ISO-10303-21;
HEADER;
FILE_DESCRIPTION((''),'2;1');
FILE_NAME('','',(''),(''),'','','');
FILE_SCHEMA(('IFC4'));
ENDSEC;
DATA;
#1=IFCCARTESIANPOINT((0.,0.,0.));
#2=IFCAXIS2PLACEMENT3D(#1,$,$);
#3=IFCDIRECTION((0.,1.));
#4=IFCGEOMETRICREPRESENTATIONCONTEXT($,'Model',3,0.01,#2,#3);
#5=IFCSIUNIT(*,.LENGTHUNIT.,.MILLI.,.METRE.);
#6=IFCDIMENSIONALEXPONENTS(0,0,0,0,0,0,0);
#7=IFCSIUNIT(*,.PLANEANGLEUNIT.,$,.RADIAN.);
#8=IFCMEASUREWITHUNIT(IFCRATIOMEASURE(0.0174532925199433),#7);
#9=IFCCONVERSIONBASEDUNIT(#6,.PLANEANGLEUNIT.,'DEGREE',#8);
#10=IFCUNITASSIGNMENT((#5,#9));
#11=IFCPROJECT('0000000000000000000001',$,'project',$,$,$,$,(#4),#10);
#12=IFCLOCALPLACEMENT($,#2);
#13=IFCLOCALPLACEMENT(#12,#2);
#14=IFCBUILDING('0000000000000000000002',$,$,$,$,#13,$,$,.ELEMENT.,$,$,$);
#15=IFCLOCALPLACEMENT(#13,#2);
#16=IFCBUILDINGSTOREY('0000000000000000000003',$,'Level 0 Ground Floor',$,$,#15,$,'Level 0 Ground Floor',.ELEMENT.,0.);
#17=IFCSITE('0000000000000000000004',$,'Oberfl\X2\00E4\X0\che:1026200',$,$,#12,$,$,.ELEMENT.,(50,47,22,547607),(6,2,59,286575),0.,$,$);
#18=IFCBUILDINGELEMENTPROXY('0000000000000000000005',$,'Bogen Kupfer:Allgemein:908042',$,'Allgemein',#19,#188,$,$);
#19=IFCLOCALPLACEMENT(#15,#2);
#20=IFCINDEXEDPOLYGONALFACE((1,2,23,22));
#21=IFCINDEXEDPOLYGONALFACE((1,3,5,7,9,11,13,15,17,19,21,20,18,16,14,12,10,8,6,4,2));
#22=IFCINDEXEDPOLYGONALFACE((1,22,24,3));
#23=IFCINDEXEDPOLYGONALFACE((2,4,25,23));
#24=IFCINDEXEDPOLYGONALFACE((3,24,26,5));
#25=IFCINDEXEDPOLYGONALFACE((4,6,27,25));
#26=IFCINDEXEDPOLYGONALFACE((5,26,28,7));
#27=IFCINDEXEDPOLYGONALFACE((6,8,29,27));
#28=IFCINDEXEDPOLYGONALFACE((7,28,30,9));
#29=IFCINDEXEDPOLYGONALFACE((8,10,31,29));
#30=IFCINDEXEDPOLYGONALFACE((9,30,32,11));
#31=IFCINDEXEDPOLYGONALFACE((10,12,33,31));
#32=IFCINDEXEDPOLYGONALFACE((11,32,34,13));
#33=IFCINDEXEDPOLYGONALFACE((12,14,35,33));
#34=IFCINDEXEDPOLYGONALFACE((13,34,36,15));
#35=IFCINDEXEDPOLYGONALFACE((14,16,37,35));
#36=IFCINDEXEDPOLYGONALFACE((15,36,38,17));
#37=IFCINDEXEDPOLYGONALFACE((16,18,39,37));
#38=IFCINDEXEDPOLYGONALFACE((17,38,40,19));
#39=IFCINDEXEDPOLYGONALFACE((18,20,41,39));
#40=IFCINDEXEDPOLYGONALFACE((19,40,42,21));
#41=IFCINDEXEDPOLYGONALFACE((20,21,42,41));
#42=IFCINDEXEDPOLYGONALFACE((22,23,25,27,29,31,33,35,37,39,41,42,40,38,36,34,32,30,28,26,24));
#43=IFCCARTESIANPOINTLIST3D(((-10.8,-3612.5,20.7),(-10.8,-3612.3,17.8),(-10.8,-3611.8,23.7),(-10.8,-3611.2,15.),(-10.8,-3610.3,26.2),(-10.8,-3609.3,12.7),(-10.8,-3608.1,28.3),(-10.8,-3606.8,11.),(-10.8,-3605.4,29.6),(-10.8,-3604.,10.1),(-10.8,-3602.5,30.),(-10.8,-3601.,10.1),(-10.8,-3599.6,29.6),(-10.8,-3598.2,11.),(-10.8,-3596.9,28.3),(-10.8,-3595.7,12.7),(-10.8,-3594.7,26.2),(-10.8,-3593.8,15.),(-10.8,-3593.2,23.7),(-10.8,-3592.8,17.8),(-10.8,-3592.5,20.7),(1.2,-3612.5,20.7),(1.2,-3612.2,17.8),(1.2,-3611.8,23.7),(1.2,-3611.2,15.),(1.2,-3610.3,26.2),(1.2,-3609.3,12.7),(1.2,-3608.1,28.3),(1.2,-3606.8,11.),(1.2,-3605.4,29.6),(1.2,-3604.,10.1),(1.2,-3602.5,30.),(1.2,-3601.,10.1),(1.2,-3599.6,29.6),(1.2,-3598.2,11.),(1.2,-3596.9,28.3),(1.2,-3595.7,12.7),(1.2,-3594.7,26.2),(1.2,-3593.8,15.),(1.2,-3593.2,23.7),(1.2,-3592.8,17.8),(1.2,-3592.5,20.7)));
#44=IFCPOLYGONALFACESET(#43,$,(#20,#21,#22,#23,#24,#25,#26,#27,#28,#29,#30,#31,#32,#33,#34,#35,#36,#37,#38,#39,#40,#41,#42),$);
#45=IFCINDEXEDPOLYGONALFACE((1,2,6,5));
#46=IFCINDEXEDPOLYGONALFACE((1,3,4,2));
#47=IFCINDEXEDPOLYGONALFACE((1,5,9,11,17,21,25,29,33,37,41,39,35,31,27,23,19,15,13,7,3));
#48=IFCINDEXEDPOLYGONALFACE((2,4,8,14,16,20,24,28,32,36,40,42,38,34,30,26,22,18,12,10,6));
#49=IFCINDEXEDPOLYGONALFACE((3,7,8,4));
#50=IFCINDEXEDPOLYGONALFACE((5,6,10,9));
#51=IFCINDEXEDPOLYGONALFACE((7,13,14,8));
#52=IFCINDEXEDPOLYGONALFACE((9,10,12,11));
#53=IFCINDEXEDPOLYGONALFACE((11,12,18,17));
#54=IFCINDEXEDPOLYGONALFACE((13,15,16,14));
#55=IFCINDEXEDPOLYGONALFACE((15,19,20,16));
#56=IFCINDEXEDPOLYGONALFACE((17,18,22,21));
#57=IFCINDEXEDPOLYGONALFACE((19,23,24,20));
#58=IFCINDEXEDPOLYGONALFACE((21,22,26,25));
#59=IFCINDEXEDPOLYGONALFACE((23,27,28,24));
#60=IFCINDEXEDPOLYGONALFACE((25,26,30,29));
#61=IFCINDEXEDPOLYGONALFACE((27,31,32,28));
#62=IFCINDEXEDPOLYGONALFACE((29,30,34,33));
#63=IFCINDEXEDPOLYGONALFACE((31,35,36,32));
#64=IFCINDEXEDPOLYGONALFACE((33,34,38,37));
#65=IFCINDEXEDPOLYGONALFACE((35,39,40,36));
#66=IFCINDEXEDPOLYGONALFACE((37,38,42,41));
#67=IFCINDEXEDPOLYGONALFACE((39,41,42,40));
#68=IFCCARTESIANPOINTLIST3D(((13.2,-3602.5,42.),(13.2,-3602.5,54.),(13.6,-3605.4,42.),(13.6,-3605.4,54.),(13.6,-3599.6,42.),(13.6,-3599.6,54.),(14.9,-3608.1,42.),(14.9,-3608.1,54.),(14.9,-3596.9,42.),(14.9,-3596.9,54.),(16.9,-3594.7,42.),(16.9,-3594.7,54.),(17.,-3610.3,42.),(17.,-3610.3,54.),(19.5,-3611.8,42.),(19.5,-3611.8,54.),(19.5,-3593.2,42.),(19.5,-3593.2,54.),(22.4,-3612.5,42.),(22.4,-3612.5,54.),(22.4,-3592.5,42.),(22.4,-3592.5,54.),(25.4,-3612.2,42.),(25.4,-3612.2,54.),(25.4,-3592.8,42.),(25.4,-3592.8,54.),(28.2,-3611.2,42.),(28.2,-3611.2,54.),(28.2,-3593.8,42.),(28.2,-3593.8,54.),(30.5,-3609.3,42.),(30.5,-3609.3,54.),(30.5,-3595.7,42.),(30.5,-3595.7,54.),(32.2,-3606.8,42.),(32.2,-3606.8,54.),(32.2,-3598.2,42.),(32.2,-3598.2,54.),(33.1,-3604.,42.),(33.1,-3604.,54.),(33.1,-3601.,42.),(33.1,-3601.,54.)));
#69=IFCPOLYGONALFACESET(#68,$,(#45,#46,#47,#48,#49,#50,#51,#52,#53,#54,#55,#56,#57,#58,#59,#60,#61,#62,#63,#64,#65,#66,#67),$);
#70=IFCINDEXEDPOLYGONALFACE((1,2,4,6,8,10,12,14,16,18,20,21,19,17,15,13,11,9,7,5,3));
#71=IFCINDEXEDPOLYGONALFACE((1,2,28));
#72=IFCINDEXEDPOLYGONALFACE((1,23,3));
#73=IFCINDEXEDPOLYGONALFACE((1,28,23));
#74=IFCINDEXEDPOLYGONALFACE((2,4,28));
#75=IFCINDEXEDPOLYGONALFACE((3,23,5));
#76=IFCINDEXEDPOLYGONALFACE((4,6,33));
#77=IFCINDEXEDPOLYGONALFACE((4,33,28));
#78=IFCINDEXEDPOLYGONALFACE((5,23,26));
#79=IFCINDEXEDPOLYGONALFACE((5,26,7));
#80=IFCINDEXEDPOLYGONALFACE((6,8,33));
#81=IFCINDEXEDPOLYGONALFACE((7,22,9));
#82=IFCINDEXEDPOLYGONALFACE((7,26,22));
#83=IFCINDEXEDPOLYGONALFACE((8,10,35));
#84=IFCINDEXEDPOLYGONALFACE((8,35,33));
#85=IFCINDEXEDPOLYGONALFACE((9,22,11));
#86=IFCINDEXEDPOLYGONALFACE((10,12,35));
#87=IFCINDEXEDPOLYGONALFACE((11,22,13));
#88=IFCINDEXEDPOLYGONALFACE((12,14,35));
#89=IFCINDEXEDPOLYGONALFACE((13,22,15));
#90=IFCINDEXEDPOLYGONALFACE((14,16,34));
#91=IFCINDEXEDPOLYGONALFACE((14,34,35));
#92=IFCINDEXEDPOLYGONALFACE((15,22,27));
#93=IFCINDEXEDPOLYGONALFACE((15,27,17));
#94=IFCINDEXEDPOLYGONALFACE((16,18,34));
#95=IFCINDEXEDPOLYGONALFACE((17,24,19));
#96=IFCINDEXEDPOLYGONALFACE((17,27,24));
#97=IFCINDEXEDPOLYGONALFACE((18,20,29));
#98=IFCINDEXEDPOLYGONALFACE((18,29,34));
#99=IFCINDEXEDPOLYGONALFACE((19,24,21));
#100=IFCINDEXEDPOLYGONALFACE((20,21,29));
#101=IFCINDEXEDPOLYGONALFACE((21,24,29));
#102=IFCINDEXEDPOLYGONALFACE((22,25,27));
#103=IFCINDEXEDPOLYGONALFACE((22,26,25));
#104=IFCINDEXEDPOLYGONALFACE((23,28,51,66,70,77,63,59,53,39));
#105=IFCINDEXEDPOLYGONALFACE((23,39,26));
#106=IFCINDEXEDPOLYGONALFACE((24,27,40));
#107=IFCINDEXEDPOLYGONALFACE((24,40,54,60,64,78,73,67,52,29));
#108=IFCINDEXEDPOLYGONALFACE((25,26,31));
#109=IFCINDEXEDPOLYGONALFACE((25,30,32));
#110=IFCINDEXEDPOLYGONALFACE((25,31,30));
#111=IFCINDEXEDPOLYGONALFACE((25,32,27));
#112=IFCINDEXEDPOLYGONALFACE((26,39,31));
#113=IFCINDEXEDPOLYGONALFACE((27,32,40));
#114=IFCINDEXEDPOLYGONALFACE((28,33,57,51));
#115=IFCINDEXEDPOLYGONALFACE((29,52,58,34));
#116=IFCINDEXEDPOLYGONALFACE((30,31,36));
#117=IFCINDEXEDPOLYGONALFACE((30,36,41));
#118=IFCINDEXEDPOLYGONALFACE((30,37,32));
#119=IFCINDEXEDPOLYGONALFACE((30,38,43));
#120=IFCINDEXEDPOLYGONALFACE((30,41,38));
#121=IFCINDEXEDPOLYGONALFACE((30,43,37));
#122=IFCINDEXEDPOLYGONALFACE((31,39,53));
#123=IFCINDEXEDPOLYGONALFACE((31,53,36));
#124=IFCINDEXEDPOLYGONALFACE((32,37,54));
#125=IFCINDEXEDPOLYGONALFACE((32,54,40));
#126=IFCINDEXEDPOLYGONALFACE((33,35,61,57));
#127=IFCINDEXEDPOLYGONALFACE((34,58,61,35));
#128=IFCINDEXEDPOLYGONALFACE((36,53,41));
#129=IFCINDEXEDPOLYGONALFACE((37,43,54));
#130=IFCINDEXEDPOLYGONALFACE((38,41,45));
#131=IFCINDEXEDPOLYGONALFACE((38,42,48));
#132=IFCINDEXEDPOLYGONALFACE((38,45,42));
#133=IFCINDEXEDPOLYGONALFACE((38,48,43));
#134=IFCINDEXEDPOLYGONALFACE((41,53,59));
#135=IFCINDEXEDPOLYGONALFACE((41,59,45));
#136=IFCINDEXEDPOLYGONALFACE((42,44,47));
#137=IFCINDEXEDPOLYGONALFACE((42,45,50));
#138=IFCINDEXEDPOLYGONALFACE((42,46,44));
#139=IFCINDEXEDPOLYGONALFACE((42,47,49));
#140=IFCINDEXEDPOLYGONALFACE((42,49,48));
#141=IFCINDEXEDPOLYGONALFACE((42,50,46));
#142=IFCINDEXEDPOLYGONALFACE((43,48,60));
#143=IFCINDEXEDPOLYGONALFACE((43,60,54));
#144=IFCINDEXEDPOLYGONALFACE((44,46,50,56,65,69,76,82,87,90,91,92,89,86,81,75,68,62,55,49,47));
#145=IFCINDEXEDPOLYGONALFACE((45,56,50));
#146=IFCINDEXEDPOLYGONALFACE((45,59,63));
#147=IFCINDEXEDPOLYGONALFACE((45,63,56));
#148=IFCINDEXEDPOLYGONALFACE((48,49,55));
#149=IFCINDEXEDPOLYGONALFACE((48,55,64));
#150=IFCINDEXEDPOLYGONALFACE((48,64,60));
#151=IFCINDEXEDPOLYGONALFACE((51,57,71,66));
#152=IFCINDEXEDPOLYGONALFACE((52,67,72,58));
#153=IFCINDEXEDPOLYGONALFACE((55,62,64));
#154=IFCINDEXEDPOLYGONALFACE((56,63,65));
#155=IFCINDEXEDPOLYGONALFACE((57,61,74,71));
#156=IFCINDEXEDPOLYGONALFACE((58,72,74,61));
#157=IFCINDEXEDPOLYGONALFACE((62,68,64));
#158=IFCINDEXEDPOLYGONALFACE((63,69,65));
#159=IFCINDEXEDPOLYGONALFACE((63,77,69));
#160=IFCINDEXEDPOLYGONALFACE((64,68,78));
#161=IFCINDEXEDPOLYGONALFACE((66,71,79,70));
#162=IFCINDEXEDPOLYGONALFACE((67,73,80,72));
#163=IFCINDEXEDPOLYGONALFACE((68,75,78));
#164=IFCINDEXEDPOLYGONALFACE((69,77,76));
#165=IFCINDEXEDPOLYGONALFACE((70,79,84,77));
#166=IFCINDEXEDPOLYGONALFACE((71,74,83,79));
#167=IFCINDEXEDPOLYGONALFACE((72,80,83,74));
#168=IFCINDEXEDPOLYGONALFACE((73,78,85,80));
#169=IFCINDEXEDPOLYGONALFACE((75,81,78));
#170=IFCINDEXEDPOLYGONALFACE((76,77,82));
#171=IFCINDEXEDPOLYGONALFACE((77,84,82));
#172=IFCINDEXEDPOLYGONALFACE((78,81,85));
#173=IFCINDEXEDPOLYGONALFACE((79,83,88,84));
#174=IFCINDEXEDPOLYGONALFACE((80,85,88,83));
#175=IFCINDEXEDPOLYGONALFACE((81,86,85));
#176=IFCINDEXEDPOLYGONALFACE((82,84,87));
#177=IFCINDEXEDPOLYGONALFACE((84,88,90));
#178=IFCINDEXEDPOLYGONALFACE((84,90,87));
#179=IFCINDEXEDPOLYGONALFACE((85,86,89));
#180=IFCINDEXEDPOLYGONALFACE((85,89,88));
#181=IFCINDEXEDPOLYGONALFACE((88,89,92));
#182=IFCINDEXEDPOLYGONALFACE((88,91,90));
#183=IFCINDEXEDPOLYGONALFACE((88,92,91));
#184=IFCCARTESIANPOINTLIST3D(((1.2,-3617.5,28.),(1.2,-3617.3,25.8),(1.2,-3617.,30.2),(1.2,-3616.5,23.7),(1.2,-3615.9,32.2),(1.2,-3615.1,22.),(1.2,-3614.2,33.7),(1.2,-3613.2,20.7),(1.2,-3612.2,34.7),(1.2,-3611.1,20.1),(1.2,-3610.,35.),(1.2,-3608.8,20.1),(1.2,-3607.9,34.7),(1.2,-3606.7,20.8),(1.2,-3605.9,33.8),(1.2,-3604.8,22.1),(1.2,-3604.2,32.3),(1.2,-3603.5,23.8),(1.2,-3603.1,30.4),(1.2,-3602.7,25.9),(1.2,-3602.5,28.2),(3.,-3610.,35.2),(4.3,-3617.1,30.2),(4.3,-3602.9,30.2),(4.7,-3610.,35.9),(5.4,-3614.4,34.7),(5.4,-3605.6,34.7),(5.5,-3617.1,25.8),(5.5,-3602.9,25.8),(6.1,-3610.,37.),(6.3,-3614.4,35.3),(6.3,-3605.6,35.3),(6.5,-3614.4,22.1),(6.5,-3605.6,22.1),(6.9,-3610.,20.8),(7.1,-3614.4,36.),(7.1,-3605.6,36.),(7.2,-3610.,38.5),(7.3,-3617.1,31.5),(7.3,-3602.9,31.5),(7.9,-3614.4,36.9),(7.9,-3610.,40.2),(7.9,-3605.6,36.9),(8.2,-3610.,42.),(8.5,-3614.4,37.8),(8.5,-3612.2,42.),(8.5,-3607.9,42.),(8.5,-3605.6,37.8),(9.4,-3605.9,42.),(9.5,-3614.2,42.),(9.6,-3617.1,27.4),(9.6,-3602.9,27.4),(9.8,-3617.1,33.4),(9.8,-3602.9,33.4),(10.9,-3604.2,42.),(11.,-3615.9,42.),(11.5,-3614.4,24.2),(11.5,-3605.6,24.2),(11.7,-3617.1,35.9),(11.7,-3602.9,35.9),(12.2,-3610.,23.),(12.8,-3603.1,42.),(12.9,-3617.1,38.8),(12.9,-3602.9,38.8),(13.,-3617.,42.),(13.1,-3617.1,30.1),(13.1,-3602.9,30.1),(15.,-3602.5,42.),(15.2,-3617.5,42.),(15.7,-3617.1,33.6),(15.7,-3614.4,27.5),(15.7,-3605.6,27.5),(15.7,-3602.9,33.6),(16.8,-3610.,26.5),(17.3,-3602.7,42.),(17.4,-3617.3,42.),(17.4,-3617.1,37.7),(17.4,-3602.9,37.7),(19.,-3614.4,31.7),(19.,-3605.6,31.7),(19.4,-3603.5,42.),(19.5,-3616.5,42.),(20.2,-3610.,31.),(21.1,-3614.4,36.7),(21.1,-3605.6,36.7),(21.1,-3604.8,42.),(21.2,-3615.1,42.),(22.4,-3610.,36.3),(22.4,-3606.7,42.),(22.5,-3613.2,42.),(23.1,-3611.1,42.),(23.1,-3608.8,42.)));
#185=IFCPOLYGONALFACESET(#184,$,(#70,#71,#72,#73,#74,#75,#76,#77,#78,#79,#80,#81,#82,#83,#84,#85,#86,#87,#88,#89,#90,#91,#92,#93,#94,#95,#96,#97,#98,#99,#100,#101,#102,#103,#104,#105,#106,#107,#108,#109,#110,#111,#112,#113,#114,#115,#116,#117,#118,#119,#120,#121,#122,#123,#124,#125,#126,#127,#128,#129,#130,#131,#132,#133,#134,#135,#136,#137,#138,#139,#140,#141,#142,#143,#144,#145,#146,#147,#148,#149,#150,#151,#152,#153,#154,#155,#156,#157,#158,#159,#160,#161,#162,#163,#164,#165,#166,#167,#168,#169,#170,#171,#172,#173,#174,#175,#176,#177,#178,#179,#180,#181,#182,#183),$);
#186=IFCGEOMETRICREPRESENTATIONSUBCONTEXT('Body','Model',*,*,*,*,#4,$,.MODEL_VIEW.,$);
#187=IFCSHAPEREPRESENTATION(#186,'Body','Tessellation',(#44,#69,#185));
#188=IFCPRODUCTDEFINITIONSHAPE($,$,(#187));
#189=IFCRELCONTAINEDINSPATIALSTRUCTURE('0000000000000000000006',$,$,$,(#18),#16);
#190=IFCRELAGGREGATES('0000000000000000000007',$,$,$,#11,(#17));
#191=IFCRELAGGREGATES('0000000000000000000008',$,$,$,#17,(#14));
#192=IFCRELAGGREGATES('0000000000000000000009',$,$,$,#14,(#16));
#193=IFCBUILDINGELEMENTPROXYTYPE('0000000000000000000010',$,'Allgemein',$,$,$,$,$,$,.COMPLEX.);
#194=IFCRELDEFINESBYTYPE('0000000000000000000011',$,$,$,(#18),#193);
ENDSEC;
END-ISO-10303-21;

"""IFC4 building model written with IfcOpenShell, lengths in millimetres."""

from ifc_helpers import new_model, entity, si_unit, converted_unit, direction, frame, frame_2d, origin, place, context, subcontext, project, spatial, circle, extrude, source, transform, mapped, type_object, type_shapes, element, save


model = new_model("IFC4")

# Units and contexts
model_context = context("Model", 3, precision=0.01, world=origin(), true_north=direction((0.0, 1.0)))
body_context = subcontext(model_context, "Body", "Model", "MODEL_VIEW")
ifc_project = project(units=[si_unit("LENGTHUNIT", "METRE", prefix="MILLI"), converted_unit("PLANEANGLEUNIT", "DEGREE", entity("IfcRatioMeasure", 0.0174532925199433), si_unit("PLANEANGLEUNIT", "RADIAN"), dimensions=[0, 0, 0, 0, 0, 0, 0])], contexts=[model_context])

# Site, building, storey
site_placement = place(None, origin())
site = spatial("IfcSite", under=ifc_project, at=site_placement, Name="Oberfläche:1026200", CompositionType="ELEMENT", RefLatitude=(50, 47, 22, 547607), RefLongitude=(6, 2, 59, 286575), RefElevation=0.0)
building_placement = place(site_placement, origin())
building = spatial("IfcBuilding", under=site, at=building_placement, CompositionType="ELEMENT")
storey_placement = place(building_placement, origin())
storey = spatial("IfcBuildingStorey", under=building, at=storey_placement, Name="Level 0 Ground Floor", LongName="Level 0 Ground Floor", CompositionType="ELEMENT", Elevation=0.0)

# Building element proxy
building_element_proxy_type = type_object("IfcBuildingElementProxyType", Name="Allgemein", PredefinedType="COMPLEX")
ifc_direction = entity("IfcDirection", [0.0, 0.0, -1.0])
trimmed_curve = entity("IfcTrimmedCurve", entity("IfcCircle", entity("IfcAxis2Placement2D", entity("IfcCartesianPoint", [-14.5, 0.0]), entity("IfcDirection", [0.0, 1.0])), 14.5), [entity("IfcParameterValue", 270.0)], [entity("IfcParameterValue", 0.0)], True, "PARAMETER")
shared_shape_1 = source(origin(), body_context, "Body", "SolidModel", [
    extrude(circle(Radius=10.0, at=frame_2d((0.0, 0.0), x_axis=(1.0, 0.0))), frame((0.0, 22.0, 0.0), z_axis=(0.0, 1.0, 0.0), x_axis=(-1.0, 0.0, 0.0)), (0.0, 0.0, 1.0), 12.0),
    extrude(circle(Radius=10.0, at=frame_2d((0.0, 0.0), x_axis=(1.0, 0.0))), frame((-34.0, 0.0, 0.0), z_axis=(1.0, 0.0, 0.0), x_axis=(0.0, 1.0, 0.0)), (0.0, 0.0, 1.0), 12.0),
    entity("IfcSurfaceCurveSweptAreaSolid", entity("IfcCircleProfileDef", "AREA", None, entity("IfcAxis2Placement2D", entity("IfcCartesianPoint", [0.0, 7.5]), entity("IfcDirection", [1.0, 0.0])), 7.5), entity("IfcAxis2Placement3D", entity("IfcCartesianPoint", [-7.5, 22.0, 0.0]), ifc_direction, entity("IfcDirection", [1.0, 0.0, 0.0])), trimmed_curve, 0.0, 90.0, entity("IfcSurfaceOfLinearExtrusion", entity("IfcArbitraryOpenProfileDef", "CURVE", None, trimmed_curve), entity("IfcAxis2Placement3D", entity("IfcCartesianPoint", [0.0, 0.0, -304.8])), ifc_direction, 1.0)),
])
type_shapes(building_element_proxy_type, [shared_shape_1])
for number, where, z_axis, x_axis, name in (
    (1, (23.2, -3602.5, 20.0), (-0.000017, 1.0, 0.0), (0.0, 0.0, -1.0), "Bogen Kupfer:Allgemein:908042"),
):
    element("IfcBuildingElementProxy", number, at=place(storey_placement, frame(where, z_axis=z_axis, x_axis=x_axis)), inside=storey, type_object=building_element_proxy_type, Name=name, ObjectType="Allgemein", context=body_context, shape_type="MappedRepresentation", body=[
        mapped(shared_shape_1, transform((0.0, 0.0, 0.0), scale=1.0)),
    ])

save(model, "model.ifc")
